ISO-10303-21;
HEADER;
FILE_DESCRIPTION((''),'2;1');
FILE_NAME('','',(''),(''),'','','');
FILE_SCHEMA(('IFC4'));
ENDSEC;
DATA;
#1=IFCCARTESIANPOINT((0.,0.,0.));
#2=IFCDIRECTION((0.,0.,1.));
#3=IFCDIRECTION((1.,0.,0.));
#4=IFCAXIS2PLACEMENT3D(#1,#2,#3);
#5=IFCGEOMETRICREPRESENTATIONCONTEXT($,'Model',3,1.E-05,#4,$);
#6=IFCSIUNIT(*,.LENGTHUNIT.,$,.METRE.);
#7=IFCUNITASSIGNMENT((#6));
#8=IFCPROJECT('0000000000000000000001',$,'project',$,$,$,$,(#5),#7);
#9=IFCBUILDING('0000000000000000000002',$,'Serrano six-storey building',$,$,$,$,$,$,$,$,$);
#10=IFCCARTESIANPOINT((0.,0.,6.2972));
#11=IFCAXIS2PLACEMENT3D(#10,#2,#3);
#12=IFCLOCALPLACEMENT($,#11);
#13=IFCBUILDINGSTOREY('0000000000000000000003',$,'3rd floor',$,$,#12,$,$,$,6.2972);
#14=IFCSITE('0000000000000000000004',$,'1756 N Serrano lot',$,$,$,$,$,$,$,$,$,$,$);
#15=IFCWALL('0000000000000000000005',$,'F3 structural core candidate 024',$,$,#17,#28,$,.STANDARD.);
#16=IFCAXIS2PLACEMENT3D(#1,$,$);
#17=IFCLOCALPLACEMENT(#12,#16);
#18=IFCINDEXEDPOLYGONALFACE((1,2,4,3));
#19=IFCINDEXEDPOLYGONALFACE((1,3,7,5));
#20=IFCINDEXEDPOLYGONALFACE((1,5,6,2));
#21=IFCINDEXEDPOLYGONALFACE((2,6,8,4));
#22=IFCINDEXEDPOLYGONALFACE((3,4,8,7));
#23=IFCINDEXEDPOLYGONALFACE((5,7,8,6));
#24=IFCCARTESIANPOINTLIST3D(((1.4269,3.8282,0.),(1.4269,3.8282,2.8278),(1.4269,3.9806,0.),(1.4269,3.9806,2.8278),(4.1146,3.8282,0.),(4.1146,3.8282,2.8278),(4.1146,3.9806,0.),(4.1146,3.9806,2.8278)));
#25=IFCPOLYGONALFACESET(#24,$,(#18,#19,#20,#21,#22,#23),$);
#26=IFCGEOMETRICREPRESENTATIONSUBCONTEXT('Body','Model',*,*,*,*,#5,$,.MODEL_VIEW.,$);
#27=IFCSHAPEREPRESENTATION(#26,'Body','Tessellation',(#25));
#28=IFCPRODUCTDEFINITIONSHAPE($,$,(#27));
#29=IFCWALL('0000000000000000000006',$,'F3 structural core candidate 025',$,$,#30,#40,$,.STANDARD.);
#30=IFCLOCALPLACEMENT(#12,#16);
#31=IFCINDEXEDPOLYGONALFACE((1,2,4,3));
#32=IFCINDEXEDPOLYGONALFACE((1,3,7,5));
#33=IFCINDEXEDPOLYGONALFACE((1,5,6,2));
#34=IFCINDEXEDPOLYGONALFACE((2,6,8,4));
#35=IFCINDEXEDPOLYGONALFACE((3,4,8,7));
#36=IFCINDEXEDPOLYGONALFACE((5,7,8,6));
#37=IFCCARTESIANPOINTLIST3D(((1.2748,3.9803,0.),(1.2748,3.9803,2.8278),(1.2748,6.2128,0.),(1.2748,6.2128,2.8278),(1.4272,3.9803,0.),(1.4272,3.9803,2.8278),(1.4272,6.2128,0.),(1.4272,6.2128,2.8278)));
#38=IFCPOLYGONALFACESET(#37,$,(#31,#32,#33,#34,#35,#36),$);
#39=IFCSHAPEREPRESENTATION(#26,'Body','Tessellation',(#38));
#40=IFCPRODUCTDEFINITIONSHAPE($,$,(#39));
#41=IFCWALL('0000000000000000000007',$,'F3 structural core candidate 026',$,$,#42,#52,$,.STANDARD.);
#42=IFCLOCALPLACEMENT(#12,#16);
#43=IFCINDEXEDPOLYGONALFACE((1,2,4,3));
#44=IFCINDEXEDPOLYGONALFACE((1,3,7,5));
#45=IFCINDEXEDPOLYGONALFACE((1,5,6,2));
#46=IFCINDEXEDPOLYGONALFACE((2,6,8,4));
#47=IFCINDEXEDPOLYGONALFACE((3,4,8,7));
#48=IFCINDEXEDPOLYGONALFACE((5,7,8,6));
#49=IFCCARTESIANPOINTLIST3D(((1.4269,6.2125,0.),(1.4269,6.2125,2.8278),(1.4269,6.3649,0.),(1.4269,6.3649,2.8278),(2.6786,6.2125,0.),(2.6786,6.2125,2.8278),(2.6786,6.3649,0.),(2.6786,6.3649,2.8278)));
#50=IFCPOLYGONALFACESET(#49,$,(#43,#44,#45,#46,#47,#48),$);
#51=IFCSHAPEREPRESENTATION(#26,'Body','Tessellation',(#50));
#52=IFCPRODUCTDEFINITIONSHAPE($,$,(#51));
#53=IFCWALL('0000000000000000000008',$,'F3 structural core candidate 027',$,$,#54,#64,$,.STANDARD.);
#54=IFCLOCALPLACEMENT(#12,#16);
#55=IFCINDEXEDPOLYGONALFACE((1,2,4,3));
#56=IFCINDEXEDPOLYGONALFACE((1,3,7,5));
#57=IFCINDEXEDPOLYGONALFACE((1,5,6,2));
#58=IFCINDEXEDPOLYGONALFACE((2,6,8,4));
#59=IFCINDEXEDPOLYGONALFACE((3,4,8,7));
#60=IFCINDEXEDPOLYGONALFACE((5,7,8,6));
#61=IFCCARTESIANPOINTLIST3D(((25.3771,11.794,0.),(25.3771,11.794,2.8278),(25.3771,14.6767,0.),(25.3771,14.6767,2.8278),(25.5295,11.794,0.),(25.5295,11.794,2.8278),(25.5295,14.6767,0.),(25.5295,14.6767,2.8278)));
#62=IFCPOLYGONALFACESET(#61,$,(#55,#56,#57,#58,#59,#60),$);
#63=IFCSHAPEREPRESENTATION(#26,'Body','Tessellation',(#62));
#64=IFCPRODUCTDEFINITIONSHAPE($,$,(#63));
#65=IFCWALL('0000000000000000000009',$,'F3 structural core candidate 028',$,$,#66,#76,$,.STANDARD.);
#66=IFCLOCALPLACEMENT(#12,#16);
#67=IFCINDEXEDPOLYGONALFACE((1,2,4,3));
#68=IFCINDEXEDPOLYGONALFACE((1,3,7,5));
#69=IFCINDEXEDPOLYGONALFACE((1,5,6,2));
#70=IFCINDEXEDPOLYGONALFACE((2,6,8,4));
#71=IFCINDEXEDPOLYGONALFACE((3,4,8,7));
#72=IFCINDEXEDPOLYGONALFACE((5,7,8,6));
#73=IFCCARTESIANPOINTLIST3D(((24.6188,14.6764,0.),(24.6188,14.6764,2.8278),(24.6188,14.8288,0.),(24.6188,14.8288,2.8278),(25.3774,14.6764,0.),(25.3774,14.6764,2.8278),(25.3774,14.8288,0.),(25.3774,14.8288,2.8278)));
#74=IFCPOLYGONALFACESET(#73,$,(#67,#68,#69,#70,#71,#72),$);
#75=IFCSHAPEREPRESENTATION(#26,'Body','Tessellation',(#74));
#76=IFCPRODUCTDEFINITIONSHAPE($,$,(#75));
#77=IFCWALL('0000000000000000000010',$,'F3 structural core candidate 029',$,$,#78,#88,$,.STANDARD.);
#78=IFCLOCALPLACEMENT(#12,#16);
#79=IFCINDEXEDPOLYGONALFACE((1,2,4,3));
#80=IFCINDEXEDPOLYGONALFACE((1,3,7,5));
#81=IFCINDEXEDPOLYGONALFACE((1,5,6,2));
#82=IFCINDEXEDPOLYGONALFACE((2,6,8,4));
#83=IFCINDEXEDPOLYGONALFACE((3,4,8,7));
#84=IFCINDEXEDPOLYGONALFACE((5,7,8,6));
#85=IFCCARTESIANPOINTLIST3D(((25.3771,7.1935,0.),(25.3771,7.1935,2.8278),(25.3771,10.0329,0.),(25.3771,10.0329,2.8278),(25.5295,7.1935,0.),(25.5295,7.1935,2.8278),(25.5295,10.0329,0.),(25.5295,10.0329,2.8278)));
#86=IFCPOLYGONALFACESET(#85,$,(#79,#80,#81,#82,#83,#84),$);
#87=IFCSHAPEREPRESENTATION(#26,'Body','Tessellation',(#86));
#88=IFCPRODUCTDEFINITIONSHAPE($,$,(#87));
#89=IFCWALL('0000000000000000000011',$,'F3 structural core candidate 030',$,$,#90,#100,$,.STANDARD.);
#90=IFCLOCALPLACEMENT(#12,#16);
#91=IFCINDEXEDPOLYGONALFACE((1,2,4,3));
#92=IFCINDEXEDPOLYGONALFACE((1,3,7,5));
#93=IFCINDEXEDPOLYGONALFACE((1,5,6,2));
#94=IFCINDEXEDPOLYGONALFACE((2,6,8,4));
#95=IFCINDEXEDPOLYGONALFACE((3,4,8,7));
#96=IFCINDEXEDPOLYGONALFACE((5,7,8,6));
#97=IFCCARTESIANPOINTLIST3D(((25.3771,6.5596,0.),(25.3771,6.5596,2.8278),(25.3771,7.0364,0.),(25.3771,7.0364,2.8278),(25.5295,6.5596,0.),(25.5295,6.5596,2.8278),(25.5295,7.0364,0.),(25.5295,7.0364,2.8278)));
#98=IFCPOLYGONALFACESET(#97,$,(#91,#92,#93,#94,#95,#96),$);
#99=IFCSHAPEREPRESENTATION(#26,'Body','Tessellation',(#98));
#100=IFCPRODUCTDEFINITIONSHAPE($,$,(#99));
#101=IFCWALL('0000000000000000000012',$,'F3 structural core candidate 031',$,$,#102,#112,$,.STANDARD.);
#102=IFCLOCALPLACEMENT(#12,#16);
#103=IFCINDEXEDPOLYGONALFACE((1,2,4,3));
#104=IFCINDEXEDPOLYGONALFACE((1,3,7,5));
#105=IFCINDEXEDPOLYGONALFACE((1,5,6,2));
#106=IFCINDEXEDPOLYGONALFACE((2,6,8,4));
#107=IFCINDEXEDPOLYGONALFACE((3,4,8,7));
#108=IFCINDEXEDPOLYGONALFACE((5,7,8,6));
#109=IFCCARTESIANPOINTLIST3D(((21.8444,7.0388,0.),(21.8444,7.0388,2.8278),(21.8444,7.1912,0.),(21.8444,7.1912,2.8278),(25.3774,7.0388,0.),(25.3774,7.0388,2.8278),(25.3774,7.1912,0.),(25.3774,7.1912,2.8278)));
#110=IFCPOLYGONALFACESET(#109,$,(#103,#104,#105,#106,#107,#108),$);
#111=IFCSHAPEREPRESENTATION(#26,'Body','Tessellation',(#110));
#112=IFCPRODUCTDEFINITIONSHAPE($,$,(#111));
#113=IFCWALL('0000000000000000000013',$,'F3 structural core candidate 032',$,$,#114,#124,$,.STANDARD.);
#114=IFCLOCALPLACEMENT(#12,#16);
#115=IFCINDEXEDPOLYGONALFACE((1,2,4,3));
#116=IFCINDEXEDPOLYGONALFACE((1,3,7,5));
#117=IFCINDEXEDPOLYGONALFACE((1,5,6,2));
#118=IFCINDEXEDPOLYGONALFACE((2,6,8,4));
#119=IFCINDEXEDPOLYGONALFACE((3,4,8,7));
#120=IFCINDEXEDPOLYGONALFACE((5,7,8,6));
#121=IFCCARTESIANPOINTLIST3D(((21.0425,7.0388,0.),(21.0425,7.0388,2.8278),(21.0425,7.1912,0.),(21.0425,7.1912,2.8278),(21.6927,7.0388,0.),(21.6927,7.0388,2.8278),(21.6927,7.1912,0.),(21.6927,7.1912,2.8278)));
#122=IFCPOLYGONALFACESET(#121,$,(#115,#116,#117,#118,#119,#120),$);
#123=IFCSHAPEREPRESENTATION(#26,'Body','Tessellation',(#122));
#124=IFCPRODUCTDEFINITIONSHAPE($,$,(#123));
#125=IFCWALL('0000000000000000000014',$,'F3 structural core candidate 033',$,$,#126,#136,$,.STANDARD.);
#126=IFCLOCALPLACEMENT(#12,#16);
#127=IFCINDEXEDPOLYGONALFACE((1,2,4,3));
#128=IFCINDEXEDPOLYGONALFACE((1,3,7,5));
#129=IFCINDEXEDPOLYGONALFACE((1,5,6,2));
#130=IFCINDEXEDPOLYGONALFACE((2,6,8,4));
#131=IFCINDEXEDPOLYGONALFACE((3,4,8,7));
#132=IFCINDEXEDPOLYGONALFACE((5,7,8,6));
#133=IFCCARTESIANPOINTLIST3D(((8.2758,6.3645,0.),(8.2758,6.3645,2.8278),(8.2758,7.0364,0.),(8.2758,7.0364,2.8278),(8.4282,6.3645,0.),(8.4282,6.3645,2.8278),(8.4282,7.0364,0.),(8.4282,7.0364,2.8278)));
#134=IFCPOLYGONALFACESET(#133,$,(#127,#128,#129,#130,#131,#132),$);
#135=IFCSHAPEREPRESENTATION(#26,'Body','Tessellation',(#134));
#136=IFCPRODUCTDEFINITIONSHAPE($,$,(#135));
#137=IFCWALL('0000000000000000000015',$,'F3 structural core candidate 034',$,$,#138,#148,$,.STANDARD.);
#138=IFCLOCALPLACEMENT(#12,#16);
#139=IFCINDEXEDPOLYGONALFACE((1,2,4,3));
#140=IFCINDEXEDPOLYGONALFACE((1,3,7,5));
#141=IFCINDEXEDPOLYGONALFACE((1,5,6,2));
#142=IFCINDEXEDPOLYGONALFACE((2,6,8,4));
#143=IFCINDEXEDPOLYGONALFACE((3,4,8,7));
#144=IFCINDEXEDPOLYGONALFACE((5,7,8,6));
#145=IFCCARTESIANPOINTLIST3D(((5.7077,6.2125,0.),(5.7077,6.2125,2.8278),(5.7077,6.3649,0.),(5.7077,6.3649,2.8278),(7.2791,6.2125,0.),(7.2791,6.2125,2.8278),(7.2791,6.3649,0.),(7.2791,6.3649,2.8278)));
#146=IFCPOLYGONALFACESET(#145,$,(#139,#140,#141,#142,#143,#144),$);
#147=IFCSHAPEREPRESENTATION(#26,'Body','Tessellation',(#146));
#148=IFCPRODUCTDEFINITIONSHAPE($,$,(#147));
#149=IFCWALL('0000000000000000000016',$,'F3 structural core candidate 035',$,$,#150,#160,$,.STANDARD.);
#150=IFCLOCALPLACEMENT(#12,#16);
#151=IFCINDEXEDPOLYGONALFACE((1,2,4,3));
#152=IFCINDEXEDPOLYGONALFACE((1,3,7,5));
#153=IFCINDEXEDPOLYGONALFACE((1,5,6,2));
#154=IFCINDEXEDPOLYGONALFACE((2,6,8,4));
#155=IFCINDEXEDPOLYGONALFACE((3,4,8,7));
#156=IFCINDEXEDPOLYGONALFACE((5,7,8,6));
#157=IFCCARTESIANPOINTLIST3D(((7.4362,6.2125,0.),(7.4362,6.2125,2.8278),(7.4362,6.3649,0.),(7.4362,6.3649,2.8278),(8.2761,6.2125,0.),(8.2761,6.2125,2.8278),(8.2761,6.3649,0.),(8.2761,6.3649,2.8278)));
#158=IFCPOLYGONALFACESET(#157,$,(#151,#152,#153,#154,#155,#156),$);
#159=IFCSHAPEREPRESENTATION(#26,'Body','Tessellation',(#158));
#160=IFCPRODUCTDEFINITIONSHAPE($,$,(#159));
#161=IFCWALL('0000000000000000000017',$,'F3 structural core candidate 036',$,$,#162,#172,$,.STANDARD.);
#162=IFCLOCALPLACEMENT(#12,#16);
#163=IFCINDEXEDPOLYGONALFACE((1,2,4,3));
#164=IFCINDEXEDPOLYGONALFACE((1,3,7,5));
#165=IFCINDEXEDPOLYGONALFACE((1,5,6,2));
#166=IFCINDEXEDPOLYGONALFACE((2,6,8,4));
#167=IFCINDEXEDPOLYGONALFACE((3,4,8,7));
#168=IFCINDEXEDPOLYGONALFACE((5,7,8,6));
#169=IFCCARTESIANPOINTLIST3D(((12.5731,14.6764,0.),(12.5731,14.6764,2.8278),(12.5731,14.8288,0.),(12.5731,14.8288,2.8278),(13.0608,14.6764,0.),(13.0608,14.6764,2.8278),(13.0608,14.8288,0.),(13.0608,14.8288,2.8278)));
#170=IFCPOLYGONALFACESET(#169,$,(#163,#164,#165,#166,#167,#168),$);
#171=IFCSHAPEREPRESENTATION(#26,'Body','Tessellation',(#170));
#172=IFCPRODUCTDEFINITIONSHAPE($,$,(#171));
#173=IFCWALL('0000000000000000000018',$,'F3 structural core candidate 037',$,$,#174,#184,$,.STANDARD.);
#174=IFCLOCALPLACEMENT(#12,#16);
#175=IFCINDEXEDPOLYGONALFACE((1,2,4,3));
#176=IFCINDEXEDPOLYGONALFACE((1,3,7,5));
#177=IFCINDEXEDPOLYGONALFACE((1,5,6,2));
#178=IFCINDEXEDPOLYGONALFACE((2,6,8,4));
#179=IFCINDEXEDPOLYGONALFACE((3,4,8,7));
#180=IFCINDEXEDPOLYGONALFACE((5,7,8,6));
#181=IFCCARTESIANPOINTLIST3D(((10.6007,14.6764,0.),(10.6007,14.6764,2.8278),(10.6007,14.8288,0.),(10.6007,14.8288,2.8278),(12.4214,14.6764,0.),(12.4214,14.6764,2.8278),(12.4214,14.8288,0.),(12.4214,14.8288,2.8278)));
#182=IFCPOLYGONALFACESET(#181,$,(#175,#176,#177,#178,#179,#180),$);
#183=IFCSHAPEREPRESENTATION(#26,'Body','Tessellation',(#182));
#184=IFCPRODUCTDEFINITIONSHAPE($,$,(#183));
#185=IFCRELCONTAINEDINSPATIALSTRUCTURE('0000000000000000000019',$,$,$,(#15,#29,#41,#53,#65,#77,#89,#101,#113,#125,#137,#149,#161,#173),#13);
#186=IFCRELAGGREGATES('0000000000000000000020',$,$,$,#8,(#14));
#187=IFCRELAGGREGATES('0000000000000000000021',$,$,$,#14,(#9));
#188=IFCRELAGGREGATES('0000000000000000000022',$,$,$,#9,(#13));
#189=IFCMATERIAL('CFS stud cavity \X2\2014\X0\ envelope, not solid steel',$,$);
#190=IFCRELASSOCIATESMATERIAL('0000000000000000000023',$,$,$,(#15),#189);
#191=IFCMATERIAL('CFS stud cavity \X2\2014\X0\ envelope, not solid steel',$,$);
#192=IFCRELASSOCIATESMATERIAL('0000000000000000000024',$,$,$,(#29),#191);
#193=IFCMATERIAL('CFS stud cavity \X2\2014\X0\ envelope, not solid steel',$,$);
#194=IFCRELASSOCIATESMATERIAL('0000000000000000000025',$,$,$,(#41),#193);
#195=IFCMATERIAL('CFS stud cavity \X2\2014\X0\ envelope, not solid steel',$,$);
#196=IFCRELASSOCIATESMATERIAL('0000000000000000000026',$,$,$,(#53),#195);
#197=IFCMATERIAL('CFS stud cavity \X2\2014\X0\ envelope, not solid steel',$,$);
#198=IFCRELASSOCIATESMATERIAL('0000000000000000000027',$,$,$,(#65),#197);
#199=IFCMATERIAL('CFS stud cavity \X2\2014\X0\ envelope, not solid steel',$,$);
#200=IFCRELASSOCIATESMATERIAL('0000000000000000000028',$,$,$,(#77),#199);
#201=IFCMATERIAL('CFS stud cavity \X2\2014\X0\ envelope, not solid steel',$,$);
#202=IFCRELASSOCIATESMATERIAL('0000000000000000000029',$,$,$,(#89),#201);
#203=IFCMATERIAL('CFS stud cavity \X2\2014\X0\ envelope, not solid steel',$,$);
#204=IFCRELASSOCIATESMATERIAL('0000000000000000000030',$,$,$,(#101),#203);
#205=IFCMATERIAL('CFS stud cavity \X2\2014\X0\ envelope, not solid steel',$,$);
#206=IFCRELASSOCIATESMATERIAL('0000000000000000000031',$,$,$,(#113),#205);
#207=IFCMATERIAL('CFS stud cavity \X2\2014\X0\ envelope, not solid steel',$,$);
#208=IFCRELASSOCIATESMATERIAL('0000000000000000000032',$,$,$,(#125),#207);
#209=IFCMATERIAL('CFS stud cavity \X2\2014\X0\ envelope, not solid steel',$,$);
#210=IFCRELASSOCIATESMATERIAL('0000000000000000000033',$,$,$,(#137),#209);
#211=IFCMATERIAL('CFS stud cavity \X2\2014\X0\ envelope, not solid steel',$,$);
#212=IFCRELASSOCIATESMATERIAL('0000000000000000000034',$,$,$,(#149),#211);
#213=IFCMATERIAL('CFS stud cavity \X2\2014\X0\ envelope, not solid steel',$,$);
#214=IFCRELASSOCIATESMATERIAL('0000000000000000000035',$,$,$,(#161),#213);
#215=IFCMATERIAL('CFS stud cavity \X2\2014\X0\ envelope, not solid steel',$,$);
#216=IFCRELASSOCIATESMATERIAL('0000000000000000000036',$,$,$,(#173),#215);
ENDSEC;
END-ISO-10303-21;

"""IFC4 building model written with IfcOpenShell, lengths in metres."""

from ifc_helpers import new_model, si_unit, frame, origin_with_axes, place, context, subcontext, project, spatial, polyline, outline, extrude, material, element, save


model = new_model("IFC4")

# Units and contexts
model_context = context("Model", 3, precision=1e-05, world=origin_with_axes())
body_context = subcontext(model_context, "Body", "Model", "MODEL_VIEW")
ifc_project = project(units=[si_unit("LENGTHUNIT", "METRE")], contexts=[model_context])

# Site, building, storey
site = spatial("IfcSite", under=ifc_project, Name="1756 N Serrano lot")
building = spatial("IfcBuilding", under=site, Name="Serrano six-storey building")
storey_placement = place(None, frame((0.0, 0.0, 6.2972), z_axis=(0.0, 0.0, 1.0), x_axis=(1.0, 0.0, 0.0)))
storey = spatial("IfcBuildingStorey", under=building, at=storey_placement, Name="3rd floor", Elevation=6.2972)

# Walls
ifc_material_1 = material(Name="CFS stud cavity — envelope, not solid steel")
wall_1_placement = place(storey_placement, frame((0.0, 0.0, -6.2972), z_axis=(0.0, 0.0, 1.0), x_axis=(1.0, 0.0, 0.0)))
element("IfcWall", 1, at=wall_1_placement, inside=storey, material=ifc_material_1, Name="F3 structural core candidate 024", PredefinedType="STANDARD", context=body_context, shape_type="SweptSolid", body=[
    extrude(outline(polyline([(4.1146, 3.9806), (4.1146, 3.8282), (1.4269, 3.8282), (1.4269, 3.9806), (4.1146, 3.9806)])), frame((0.0, 0.0, 6.2972)), (0.0, 0.0, 1.0), 2.8278),
])
ifc_material_2 = material(Name="CFS stud cavity — envelope, not solid steel")
wall_2_placement = place(storey_placement, frame((0.0, 0.0, -6.2972), z_axis=(0.0, 0.0, 1.0), x_axis=(1.0, 0.0, 0.0)))
element("IfcWall", 2, at=wall_2_placement, inside=storey, material=ifc_material_2, Name="F3 structural core candidate 025", PredefinedType="STANDARD", context=body_context, shape_type="SweptSolid", body=[
    extrude(outline(polyline([(1.4272, 3.9803), (1.2748, 3.9803), (1.2748, 6.2128), (1.4272, 6.2128), (1.4272, 3.9803)])), frame((0.0, 0.0, 6.2972)), (0.0, 0.0, 1.0), 2.8278),
])
ifc_material_3 = material(Name="CFS stud cavity — envelope, not solid steel")
wall_3_placement = place(storey_placement, frame((0.0, 0.0, -6.2972), z_axis=(0.0, 0.0, 1.0), x_axis=(1.0, 0.0, 0.0)))
element("IfcWall", 3, at=wall_3_placement, inside=storey, material=ifc_material_3, Name="F3 structural core candidate 026", PredefinedType="STANDARD", context=body_context, shape_type="SweptSolid", body=[
    extrude(outline(polyline([(2.6786, 6.3649), (2.6786, 6.2125), (1.4269, 6.2125), (1.4269, 6.3649), (2.6786, 6.3649)])), frame((0.0, 0.0, 6.2972)), (0.0, 0.0, 1.0), 2.8278),
])
ifc_material_4 = material(Name="CFS stud cavity — envelope, not solid steel")
wall_4_placement = place(storey_placement, frame((0.0, 0.0, -6.2972), z_axis=(0.0, 0.0, 1.0), x_axis=(1.0, 0.0, 0.0)))
element("IfcWall", 4, at=wall_4_placement, inside=storey, material=ifc_material_4, Name="F3 structural core candidate 027", PredefinedType="STANDARD", context=body_context, shape_type="SweptSolid", body=[
    extrude(outline(polyline([(25.5295, 11.794), (25.3771, 11.794), (25.3771, 14.6767), (25.5295, 14.6767), (25.5295, 11.794)])), frame((0.0, 0.0, 6.2972)), (0.0, 0.0, 1.0), 2.8278),
])
ifc_material_5 = material(Name="CFS stud cavity — envelope, not solid steel")
wall_5_placement = place(storey_placement, frame((0.0, 0.0, -6.2972), z_axis=(0.0, 0.0, 1.0), x_axis=(1.0, 0.0, 0.0)))
element("IfcWall", 5, at=wall_5_placement, inside=storey, material=ifc_material_5, Name="F3 structural core candidate 028", PredefinedType="STANDARD", context=body_context, shape_type="SweptSolid", body=[
    extrude(outline(polyline([(25.3774, 14.8288), (25.3774, 14.6764), (24.6188, 14.6764), (24.6188, 14.8288), (25.3774, 14.8288)])), frame((0.0, 0.0, 6.2972)), (0.0, 0.0, 1.0), 2.8278),
])
ifc_material_6 = material(Name="CFS stud cavity — envelope, not solid steel")
wall_6_placement = place(storey_placement, frame((0.0, 0.0, -6.2972), z_axis=(0.0, 0.0, 1.0), x_axis=(1.0, 0.0, 0.0)))
element("IfcWall", 6, at=wall_6_placement, inside=storey, material=ifc_material_6, Name="F3 structural core candidate 029", PredefinedType="STANDARD", context=body_context, shape_type="SweptSolid", body=[
    extrude(outline(polyline([(25.5295, 7.1935), (25.3771, 7.1935), (25.3771, 10.0329), (25.5295, 10.0329), (25.5295, 7.1935)])), frame((0.0, 0.0, 6.2972)), (0.0, 0.0, 1.0), 2.8278),
])
ifc_material_7 = material(Name="CFS stud cavity — envelope, not solid steel")
wall_7_placement = place(storey_placement, frame((0.0, 0.0, -6.2972), z_axis=(0.0, 0.0, 1.0), x_axis=(1.0, 0.0, 0.0)))
element("IfcWall", 7, at=wall_7_placement, inside=storey, material=ifc_material_7, Name="F3 structural core candidate 030", PredefinedType="STANDARD", context=body_context, shape_type="SweptSolid", body=[
    extrude(outline(polyline([(25.5295, 6.5596), (25.3771, 6.5596), (25.3771, 7.0364), (25.5295, 7.0364), (25.5295, 6.5596)])), frame((0.0, 0.0, 6.2972)), (0.0, 0.0, 1.0), 2.8278),
])
ifc_material_8 = material(Name="CFS stud cavity — envelope, not solid steel")
wall_8_placement = place(storey_placement, frame((0.0, 0.0, -6.2972), z_axis=(0.0, 0.0, 1.0), x_axis=(1.0, 0.0, 0.0)))
element("IfcWall", 8, at=wall_8_placement, inside=storey, material=ifc_material_8, Name="F3 structural core candidate 031", PredefinedType="STANDARD", context=body_context, shape_type="SweptSolid", body=[
    extrude(outline(polyline([(25.3774, 7.1912), (25.3774, 7.0388), (21.8444, 7.0388), (21.8444, 7.1912), (25.3774, 7.1912)])), frame((0.0, 0.0, 6.2972)), (0.0, 0.0, 1.0), 2.8278),
])
ifc_material_9 = material(Name="CFS stud cavity — envelope, not solid steel")
wall_9_placement = place(storey_placement, frame((0.0, 0.0, -6.2972), z_axis=(0.0, 0.0, 1.0), x_axis=(1.0, 0.0, 0.0)))
element("IfcWall", 9, at=wall_9_placement, inside=storey, material=ifc_material_9, Name="F3 structural core candidate 032", PredefinedType="STANDARD", context=body_context, shape_type="SweptSolid", body=[
    extrude(outline(polyline([(21.6927, 7.1912), (21.6927, 7.0388), (21.0425, 7.0388), (21.0425, 7.1912), (21.6927, 7.1912)])), frame((0.0, 0.0, 6.2972)), (0.0, 0.0, 1.0), 2.8278),
])
ifc_material_10 = material(Name="CFS stud cavity — envelope, not solid steel")
wall_10_placement = place(storey_placement, frame((0.0, 0.0, -6.2972), z_axis=(0.0, 0.0, 1.0), x_axis=(1.0, 0.0, 0.0)))
element("IfcWall", 10, at=wall_10_placement, inside=storey, material=ifc_material_10, Name="F3 structural core candidate 033", PredefinedType="STANDARD", context=body_context, shape_type="SweptSolid", body=[
    extrude(outline(polyline([(8.4282, 6.3645), (8.2758, 6.3645), (8.2758, 7.0364), (8.4282, 7.0364), (8.4282, 6.3645)])), frame((0.0, 0.0, 6.2972)), (0.0, 0.0, 1.0), 2.8278),
])
ifc_material_11 = material(Name="CFS stud cavity — envelope, not solid steel")
wall_11_placement = place(storey_placement, frame((0.0, 0.0, -6.2972), z_axis=(0.0, 0.0, 1.0), x_axis=(1.0, 0.0, 0.0)))
element("IfcWall", 11, at=wall_11_placement, inside=storey, material=ifc_material_11, Name="F3 structural core candidate 034", PredefinedType="STANDARD", context=body_context, shape_type="SweptSolid", body=[
    extrude(outline(polyline([(7.2791, 6.3649), (7.2791, 6.2125), (5.7077, 6.2125), (5.7077, 6.3649), (7.2791, 6.3649)])), frame((0.0, 0.0, 6.2972)), (0.0, 0.0, 1.0), 2.8278),
])
ifc_material_12 = material(Name="CFS stud cavity — envelope, not solid steel")
wall_12_placement = place(storey_placement, frame((0.0, 0.0, -6.2972), z_axis=(0.0, 0.0, 1.0), x_axis=(1.0, 0.0, 0.0)))
element("IfcWall", 12, at=wall_12_placement, inside=storey, material=ifc_material_12, Name="F3 structural core candidate 035", PredefinedType="STANDARD", context=body_context, shape_type="SweptSolid", body=[
    extrude(outline(polyline([(8.2761, 6.3649), (8.2761, 6.2125), (7.4362, 6.2125), (7.4362, 6.3649), (8.2761, 6.3649)])), frame((0.0, 0.0, 6.2972)), (0.0, 0.0, 1.0), 2.8278),
])
ifc_material_13 = material(Name="CFS stud cavity — envelope, not solid steel")
wall_13_placement = place(storey_placement, frame((0.0, 0.0, -6.2972), z_axis=(0.0, 0.0, 1.0), x_axis=(1.0, 0.0, 0.0)))
element("IfcWall", 13, at=wall_13_placement, inside=storey, material=ifc_material_13, Name="F3 structural core candidate 036", PredefinedType="STANDARD", context=body_context, shape_type="SweptSolid", body=[
    extrude(outline(polyline([(13.0608, 14.8288), (13.0608, 14.6764), (12.5731, 14.6764), (12.5731, 14.8288), (13.0608, 14.8288)])), frame((0.0, 0.0, 6.2972)), (0.0, 0.0, 1.0), 2.8278),
])
ifc_material_14 = material(Name="CFS stud cavity — envelope, not solid steel")
wall_14_placement = place(storey_placement, frame((0.0, 0.0, -6.2972), z_axis=(0.0, 0.0, 1.0), x_axis=(1.0, 0.0, 0.0)))
element("IfcWall", 14, at=wall_14_placement, inside=storey, material=ifc_material_14, Name="F3 structural core candidate 037", PredefinedType="STANDARD", context=body_context, shape_type="SweptSolid", body=[
    extrude(outline(polyline([(12.4214, 14.8288), (12.4214, 14.6764), (10.6007, 14.6764), (10.6007, 14.8288), (12.4214, 14.8288)])), frame((0.0, 0.0, 6.2972)), (0.0, 0.0, 1.0), 2.8278),
])

save(model, "model.ifc")
